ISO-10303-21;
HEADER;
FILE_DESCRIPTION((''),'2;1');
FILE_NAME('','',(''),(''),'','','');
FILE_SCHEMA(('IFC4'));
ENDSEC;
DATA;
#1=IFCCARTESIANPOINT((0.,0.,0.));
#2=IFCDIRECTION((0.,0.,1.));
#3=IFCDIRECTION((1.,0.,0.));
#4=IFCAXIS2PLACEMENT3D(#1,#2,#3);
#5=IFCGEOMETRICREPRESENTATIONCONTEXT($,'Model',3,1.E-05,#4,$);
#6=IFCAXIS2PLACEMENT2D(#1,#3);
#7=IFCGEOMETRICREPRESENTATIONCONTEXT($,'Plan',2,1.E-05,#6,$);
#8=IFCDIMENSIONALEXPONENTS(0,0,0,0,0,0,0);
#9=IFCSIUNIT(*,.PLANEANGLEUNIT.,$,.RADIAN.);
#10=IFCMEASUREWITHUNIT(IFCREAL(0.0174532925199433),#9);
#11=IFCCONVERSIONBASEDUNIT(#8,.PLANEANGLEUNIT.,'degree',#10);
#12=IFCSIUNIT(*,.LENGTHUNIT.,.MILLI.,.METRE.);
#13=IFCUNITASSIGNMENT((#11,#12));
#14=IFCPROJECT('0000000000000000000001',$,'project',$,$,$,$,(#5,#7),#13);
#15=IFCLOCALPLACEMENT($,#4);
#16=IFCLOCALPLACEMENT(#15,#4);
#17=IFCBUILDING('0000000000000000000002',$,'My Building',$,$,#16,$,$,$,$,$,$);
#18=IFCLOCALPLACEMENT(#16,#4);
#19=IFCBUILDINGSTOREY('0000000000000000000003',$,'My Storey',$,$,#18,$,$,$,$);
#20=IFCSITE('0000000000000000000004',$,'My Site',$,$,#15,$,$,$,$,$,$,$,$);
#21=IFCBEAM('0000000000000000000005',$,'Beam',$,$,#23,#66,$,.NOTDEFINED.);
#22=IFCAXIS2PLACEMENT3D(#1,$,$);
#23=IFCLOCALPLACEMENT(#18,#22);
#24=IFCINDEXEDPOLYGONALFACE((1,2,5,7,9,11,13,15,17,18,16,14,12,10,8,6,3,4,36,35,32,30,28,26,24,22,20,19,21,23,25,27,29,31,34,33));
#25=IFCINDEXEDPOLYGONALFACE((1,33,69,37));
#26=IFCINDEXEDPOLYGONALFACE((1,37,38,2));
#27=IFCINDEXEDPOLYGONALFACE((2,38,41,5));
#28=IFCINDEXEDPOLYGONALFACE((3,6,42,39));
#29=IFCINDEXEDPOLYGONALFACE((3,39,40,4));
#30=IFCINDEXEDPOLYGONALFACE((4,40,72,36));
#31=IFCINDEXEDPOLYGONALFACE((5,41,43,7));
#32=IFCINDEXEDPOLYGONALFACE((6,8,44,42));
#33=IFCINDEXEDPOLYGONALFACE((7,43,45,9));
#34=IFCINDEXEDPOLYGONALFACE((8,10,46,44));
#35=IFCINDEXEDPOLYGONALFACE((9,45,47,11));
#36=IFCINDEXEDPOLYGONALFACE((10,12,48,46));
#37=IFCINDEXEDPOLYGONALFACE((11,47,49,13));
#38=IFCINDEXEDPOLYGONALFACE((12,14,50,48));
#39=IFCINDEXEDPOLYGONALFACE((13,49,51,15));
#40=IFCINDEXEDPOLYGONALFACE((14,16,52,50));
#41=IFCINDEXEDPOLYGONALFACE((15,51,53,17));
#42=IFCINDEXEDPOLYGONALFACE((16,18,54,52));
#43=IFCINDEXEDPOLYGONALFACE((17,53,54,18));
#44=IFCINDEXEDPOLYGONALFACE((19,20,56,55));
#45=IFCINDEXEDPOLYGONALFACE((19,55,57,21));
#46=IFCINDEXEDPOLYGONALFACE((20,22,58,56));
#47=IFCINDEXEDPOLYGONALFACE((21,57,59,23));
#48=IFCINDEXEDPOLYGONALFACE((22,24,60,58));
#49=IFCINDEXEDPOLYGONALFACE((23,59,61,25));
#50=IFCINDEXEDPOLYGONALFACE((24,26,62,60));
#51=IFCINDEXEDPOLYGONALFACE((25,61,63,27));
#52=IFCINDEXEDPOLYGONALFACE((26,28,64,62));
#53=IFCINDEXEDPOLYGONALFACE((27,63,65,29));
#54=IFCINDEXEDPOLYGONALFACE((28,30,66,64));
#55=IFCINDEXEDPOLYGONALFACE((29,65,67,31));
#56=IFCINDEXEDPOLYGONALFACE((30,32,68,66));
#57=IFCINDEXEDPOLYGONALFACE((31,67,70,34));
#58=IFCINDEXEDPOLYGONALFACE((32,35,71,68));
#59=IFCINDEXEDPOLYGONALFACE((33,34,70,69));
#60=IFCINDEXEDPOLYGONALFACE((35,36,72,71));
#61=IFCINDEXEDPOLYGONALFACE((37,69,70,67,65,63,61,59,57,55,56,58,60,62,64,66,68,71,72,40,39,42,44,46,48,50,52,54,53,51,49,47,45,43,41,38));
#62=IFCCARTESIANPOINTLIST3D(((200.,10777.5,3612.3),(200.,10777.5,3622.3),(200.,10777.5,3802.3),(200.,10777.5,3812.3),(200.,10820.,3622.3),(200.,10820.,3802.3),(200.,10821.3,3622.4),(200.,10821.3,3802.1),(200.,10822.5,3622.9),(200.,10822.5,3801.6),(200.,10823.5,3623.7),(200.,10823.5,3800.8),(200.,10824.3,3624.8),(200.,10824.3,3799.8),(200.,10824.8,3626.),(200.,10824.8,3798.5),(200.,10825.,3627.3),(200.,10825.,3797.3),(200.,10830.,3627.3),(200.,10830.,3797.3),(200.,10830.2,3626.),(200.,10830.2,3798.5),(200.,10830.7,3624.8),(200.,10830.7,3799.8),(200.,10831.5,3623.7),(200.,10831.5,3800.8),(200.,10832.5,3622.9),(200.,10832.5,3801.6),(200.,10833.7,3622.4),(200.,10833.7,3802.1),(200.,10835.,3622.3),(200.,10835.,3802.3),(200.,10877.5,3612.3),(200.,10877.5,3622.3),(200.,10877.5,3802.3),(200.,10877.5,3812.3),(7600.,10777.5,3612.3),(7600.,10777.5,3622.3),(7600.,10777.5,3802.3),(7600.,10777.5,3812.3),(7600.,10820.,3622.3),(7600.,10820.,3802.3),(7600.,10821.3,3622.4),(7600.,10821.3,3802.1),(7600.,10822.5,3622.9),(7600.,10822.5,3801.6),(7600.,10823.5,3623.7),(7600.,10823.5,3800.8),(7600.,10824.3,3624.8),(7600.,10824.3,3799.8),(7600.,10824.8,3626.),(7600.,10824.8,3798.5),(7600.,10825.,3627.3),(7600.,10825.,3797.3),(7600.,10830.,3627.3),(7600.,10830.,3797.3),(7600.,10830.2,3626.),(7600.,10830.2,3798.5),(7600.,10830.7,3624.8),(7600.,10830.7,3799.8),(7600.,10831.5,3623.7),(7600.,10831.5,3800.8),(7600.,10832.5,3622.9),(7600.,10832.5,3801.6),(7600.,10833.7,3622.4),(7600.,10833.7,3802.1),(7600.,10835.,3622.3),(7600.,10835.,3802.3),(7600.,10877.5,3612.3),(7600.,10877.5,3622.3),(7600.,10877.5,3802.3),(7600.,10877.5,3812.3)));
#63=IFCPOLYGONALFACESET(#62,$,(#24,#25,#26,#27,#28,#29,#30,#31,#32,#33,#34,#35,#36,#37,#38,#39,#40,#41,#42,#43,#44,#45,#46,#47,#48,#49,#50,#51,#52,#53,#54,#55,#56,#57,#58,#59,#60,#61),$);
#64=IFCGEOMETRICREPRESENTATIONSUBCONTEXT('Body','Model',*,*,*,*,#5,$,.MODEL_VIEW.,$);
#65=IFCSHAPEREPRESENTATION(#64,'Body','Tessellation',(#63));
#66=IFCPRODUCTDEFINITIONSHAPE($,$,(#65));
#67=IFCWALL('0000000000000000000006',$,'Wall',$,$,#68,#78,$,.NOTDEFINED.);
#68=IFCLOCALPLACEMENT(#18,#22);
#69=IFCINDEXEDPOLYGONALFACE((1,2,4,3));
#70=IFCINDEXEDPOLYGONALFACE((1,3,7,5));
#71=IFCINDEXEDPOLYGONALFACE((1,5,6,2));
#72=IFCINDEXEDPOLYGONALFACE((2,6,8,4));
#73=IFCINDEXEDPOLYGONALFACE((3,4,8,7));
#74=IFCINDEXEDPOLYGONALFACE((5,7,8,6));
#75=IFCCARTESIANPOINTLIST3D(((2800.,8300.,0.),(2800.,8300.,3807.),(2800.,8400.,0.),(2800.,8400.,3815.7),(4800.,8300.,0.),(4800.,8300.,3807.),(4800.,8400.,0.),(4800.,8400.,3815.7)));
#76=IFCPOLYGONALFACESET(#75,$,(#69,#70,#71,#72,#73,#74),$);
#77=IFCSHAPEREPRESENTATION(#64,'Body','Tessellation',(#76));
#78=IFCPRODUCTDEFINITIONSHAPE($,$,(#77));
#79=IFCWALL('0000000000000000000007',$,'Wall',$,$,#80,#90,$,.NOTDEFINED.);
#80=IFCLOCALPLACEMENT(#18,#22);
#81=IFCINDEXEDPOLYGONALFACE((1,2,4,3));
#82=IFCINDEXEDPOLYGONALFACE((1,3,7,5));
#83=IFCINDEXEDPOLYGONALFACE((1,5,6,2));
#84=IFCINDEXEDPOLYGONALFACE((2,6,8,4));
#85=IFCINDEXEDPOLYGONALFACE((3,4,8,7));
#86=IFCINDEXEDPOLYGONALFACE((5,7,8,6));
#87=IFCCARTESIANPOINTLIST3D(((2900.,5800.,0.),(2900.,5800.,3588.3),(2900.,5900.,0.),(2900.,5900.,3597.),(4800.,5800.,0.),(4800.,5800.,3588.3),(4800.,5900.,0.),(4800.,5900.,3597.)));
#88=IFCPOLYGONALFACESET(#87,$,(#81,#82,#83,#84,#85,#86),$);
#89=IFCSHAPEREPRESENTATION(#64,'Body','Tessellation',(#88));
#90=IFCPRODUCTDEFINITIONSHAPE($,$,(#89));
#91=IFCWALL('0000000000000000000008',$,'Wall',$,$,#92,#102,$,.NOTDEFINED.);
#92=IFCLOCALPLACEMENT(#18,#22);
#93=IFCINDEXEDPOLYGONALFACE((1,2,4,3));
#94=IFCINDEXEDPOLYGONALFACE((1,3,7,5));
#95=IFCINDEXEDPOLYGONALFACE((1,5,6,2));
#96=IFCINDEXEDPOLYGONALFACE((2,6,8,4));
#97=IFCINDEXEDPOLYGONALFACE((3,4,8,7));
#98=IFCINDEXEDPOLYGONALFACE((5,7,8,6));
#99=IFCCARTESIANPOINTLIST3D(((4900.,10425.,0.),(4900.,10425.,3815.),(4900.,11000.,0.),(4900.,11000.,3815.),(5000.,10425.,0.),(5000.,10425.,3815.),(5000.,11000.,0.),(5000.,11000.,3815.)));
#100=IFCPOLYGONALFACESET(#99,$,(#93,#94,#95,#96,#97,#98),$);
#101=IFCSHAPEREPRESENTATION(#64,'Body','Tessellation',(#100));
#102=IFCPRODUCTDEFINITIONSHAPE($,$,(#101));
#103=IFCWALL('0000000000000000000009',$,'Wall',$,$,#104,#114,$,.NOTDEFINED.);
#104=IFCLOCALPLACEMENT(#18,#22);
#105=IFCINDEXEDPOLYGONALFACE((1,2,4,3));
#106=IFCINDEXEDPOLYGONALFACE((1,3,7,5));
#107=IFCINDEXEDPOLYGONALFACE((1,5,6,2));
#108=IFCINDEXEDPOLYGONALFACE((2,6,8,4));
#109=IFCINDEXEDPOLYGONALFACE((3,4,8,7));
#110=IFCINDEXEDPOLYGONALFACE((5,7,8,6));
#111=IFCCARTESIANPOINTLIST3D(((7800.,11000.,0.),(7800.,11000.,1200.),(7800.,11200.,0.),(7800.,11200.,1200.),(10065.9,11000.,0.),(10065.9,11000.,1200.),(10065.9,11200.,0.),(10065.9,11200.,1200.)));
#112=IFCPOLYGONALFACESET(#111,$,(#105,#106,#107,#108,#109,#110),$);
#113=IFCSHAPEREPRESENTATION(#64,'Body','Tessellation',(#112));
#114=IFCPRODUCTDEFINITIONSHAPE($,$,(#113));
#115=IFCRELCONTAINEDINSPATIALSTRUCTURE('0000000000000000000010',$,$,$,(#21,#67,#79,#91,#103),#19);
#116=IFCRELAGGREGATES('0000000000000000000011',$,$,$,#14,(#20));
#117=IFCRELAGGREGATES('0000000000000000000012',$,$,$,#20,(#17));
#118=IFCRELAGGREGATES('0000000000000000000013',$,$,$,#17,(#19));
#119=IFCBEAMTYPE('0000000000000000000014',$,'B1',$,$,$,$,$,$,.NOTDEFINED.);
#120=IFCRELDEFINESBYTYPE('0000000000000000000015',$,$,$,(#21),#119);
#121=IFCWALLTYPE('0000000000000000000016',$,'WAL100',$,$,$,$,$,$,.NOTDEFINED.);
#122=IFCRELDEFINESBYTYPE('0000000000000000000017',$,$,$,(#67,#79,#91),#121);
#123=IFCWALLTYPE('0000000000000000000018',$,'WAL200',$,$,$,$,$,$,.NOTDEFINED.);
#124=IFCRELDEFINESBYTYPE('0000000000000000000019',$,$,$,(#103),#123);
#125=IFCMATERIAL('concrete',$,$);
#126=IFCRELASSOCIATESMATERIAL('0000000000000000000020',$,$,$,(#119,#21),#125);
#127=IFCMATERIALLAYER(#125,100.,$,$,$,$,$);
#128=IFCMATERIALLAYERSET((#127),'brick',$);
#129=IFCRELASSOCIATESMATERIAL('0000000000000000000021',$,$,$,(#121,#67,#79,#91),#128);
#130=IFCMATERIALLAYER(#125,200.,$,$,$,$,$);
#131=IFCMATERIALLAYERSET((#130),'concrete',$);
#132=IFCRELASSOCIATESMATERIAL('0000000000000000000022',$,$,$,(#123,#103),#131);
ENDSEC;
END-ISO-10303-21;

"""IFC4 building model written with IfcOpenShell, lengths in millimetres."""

from ifc_helpers import new_model, entity, si_unit, converted_unit, frame, frame_2d, origin_with_axes, place, context, subcontext, project, spatial, indexed_curve, i_section, outline, extrude, clip, halfspace, material, layer, layer_set, layer_usage, material_profile, profile_set, profile_usage, type_object, element, save


model = new_model("IFC4")

# Units and contexts
model_context = context("Model", 3, precision=1e-05, world=origin_with_axes())
plan_context = context("Plan", 2, precision=1e-05, world=frame_2d((0.0, 0.0, 0.0), x_axis=(1.0, 0.0, 0.0)))
body_context = subcontext(model_context, "Body", "Model", "MODEL_VIEW")
ifc_project = project(units=[converted_unit("PLANEANGLEUNIT", "degree", entity("IfcReal", 0.0174532925199433), si_unit("PLANEANGLEUNIT", "RADIAN"), dimensions=[0, 0, 0, 0, 0, 0, 0]), si_unit("LENGTHUNIT", "METRE", prefix="MILLI")], contexts=[model_context, plan_context])

# Site, building, storey
site_placement = place(None, origin_with_axes())
site = spatial("IfcSite", under=ifc_project, at=site_placement, Name="My Site")
building_placement = place(site_placement, origin_with_axes())
building = spatial("IfcBuilding", under=site, at=building_placement, Name="My Building")
storey_placement = place(building_placement, origin_with_axes())
storey = spatial("IfcBuildingStorey", under=building, at=storey_placement, Name="My Storey")

# Beam
ifc_material = material(Name="concrete")
ifc_material_profile = material_profile(ifc_material, i_section(OverallWidth=100.0, OverallDepth=200.0, WebThickness=5.0, FlangeThickness=10.0, FilletRadius=5.0))
ifc_profile_set = profile_set([ifc_material_profile])
beam_type = type_object("IfcBeamType", Name="B1", PredefinedType="NOTDEFINED", material=ifc_profile_set)
ifc_profile_usage_1 = profile_usage(ifc_profile_set, cardinal=5)
beam_1_placement = place(storey_placement, frame((200.0, 10827.5, 3712.3), z_axis=(1.0, 0.0, 0.0), x_axis=(0.0, 1.0, 0.0)))
element("IfcBeam", 1, at=beam_1_placement, inside=storey, type_object=beam_type, material=ifc_profile_usage_1, Name="Beam", PredefinedType="NOTDEFINED", context=body_context, shape_type="SweptSolid", body=[
    extrude(i_section(OverallWidth=100.0, OverallDepth=200.0, WebThickness=5.0, FlangeThickness=10.0, FilletRadius=5.0), origin_with_axes(), (0.0, 0.0, 1.0), 7400.0),
])

# Walls
ifc_layer_1 = layer(ifc_material, 100.0)
ifc_layer_set_1 = layer_set([ifc_layer_1], Name="brick")
ifc_layer_usage_1 = layer_usage(ifc_layer_set_1, "AXIS2", "POSITIVE", 0.0)
wall_type_1 = type_object("IfcWallType", Name="WAL100", PredefinedType="NOTDEFINED", material=ifc_layer_set_1)
wall_1_placement = place(storey_placement, frame((4800.0, 8400.0, 0.0), z_axis=(0.0, 0.0, 1.0), x_axis=(-1.0, 0.0, 0.0)))
element("IfcWall", 2, at=wall_1_placement, inside=storey, type_object=wall_type_1, material=ifc_layer_usage_1, Name="Wall", PredefinedType="NOTDEFINED", context=body_context, shape_type="Clipping", body=[
    clip(extrude(outline(indexed_curve([(0.0, 0.0), (0.0, 100.0), (2000.0, 100.0), (2000.0, 0.0), (0.0, 0.0)], self_intersect=False)), origin_with_axes(), (0.0, 0.0, 1.0), 3815.7), halfspace(frame((0.0, 0.0, 3815.7), z_axis=(0.0, 0.087156, 0.996195), x_axis=(-1.0, 0.0, 0.0)), False)),
])
ifc_layer_usage_2 = layer_usage(ifc_layer_set_1, "AXIS2", "POSITIVE", 0.0)
wall_2_placement = place(storey_placement, frame((2900.0, 5800.0, 0.0), z_axis=(0.0, 0.0, 1.0), x_axis=(1.0, 0.0, 0.0)))
element("IfcWall", 3, at=wall_2_placement, inside=storey, type_object=wall_type_1, material=ifc_layer_usage_2, Name="Wall", PredefinedType="NOTDEFINED", context=body_context, shape_type="Clipping", body=[
    clip(extrude(outline(indexed_curve([(0.0, 0.0), (0.0, 100.0), (1900.0, 100.0), (1900.0, 0.0), (0.0, 0.0)], self_intersect=False)), origin_with_axes(), (0.0, 0.0, 1.0), 3597.0), halfspace(frame((0.0, 100.0, 3597.0), z_axis=(0.0, -0.087156, 0.996195), x_axis=(1.0, 0.0, 0.0)), False)),
])
ifc_layer_usage_3 = layer_usage(ifc_layer_set_1, "AXIS2", "POSITIVE", 0.0)
wall_3_placement = place(storey_placement, frame((4900.0, 11000.0, 0.0), z_axis=(0.0, 0.0, 1.0), x_axis=(0.0, -1.0, 0.0)))
element("IfcWall", 4, at=wall_3_placement, inside=storey, type_object=wall_type_1, material=ifc_layer_usage_3, Name="Wall", PredefinedType="NOTDEFINED", context=body_context, shape_type="Clipping", body=[
    clip(extrude(outline(indexed_curve([(0.0, 0.0), (0.0, 100.0), (575.0, 100.0), (575.0, 0.0), (0.0, 0.0)], self_intersect=False)), origin_with_axes(), (0.0, 0.0, 1.0), 3815.0), halfspace(frame((0.0, 0.0, 3815.0), z_axis=(0.0, 0.0, 1.0), x_axis=(0.0, 1.0, 0.0)), False)),
])
ifc_layer_2 = layer(ifc_material, 200.0)
ifc_layer_set_2 = layer_set([ifc_layer_2], Name="concrete")
ifc_layer_usage_4 = layer_usage(ifc_layer_set_2, "AXIS2", "POSITIVE", 0.0)
wall_type_2 = type_object("IfcWallType", Name="WAL200", PredefinedType="NOTDEFINED", material=ifc_layer_set_2)
wall_4_placement = place(storey_placement, frame((10065.9, 11200.0, 0.0), z_axis=(0.0, 0.0, 1.0), x_axis=(-1.0, 0.0, 0.0)))
element("IfcWall", 5, at=wall_4_placement, inside=storey, type_object=wall_type_2, material=ifc_layer_usage_4, Name="Wall", PredefinedType="NOTDEFINED", context=body_context, shape_type="SweptSolid", body=[
    extrude(outline(indexed_curve([(0.0, 0.0), (0.0, 200.0), (2265.9, 200.0), (2265.9, 0.0), (0.0, 0.0)], self_intersect=False)), origin_with_axes(), (0.0, 0.0, 1.0), 1200.0),
])

save(model, "model.ifc")
